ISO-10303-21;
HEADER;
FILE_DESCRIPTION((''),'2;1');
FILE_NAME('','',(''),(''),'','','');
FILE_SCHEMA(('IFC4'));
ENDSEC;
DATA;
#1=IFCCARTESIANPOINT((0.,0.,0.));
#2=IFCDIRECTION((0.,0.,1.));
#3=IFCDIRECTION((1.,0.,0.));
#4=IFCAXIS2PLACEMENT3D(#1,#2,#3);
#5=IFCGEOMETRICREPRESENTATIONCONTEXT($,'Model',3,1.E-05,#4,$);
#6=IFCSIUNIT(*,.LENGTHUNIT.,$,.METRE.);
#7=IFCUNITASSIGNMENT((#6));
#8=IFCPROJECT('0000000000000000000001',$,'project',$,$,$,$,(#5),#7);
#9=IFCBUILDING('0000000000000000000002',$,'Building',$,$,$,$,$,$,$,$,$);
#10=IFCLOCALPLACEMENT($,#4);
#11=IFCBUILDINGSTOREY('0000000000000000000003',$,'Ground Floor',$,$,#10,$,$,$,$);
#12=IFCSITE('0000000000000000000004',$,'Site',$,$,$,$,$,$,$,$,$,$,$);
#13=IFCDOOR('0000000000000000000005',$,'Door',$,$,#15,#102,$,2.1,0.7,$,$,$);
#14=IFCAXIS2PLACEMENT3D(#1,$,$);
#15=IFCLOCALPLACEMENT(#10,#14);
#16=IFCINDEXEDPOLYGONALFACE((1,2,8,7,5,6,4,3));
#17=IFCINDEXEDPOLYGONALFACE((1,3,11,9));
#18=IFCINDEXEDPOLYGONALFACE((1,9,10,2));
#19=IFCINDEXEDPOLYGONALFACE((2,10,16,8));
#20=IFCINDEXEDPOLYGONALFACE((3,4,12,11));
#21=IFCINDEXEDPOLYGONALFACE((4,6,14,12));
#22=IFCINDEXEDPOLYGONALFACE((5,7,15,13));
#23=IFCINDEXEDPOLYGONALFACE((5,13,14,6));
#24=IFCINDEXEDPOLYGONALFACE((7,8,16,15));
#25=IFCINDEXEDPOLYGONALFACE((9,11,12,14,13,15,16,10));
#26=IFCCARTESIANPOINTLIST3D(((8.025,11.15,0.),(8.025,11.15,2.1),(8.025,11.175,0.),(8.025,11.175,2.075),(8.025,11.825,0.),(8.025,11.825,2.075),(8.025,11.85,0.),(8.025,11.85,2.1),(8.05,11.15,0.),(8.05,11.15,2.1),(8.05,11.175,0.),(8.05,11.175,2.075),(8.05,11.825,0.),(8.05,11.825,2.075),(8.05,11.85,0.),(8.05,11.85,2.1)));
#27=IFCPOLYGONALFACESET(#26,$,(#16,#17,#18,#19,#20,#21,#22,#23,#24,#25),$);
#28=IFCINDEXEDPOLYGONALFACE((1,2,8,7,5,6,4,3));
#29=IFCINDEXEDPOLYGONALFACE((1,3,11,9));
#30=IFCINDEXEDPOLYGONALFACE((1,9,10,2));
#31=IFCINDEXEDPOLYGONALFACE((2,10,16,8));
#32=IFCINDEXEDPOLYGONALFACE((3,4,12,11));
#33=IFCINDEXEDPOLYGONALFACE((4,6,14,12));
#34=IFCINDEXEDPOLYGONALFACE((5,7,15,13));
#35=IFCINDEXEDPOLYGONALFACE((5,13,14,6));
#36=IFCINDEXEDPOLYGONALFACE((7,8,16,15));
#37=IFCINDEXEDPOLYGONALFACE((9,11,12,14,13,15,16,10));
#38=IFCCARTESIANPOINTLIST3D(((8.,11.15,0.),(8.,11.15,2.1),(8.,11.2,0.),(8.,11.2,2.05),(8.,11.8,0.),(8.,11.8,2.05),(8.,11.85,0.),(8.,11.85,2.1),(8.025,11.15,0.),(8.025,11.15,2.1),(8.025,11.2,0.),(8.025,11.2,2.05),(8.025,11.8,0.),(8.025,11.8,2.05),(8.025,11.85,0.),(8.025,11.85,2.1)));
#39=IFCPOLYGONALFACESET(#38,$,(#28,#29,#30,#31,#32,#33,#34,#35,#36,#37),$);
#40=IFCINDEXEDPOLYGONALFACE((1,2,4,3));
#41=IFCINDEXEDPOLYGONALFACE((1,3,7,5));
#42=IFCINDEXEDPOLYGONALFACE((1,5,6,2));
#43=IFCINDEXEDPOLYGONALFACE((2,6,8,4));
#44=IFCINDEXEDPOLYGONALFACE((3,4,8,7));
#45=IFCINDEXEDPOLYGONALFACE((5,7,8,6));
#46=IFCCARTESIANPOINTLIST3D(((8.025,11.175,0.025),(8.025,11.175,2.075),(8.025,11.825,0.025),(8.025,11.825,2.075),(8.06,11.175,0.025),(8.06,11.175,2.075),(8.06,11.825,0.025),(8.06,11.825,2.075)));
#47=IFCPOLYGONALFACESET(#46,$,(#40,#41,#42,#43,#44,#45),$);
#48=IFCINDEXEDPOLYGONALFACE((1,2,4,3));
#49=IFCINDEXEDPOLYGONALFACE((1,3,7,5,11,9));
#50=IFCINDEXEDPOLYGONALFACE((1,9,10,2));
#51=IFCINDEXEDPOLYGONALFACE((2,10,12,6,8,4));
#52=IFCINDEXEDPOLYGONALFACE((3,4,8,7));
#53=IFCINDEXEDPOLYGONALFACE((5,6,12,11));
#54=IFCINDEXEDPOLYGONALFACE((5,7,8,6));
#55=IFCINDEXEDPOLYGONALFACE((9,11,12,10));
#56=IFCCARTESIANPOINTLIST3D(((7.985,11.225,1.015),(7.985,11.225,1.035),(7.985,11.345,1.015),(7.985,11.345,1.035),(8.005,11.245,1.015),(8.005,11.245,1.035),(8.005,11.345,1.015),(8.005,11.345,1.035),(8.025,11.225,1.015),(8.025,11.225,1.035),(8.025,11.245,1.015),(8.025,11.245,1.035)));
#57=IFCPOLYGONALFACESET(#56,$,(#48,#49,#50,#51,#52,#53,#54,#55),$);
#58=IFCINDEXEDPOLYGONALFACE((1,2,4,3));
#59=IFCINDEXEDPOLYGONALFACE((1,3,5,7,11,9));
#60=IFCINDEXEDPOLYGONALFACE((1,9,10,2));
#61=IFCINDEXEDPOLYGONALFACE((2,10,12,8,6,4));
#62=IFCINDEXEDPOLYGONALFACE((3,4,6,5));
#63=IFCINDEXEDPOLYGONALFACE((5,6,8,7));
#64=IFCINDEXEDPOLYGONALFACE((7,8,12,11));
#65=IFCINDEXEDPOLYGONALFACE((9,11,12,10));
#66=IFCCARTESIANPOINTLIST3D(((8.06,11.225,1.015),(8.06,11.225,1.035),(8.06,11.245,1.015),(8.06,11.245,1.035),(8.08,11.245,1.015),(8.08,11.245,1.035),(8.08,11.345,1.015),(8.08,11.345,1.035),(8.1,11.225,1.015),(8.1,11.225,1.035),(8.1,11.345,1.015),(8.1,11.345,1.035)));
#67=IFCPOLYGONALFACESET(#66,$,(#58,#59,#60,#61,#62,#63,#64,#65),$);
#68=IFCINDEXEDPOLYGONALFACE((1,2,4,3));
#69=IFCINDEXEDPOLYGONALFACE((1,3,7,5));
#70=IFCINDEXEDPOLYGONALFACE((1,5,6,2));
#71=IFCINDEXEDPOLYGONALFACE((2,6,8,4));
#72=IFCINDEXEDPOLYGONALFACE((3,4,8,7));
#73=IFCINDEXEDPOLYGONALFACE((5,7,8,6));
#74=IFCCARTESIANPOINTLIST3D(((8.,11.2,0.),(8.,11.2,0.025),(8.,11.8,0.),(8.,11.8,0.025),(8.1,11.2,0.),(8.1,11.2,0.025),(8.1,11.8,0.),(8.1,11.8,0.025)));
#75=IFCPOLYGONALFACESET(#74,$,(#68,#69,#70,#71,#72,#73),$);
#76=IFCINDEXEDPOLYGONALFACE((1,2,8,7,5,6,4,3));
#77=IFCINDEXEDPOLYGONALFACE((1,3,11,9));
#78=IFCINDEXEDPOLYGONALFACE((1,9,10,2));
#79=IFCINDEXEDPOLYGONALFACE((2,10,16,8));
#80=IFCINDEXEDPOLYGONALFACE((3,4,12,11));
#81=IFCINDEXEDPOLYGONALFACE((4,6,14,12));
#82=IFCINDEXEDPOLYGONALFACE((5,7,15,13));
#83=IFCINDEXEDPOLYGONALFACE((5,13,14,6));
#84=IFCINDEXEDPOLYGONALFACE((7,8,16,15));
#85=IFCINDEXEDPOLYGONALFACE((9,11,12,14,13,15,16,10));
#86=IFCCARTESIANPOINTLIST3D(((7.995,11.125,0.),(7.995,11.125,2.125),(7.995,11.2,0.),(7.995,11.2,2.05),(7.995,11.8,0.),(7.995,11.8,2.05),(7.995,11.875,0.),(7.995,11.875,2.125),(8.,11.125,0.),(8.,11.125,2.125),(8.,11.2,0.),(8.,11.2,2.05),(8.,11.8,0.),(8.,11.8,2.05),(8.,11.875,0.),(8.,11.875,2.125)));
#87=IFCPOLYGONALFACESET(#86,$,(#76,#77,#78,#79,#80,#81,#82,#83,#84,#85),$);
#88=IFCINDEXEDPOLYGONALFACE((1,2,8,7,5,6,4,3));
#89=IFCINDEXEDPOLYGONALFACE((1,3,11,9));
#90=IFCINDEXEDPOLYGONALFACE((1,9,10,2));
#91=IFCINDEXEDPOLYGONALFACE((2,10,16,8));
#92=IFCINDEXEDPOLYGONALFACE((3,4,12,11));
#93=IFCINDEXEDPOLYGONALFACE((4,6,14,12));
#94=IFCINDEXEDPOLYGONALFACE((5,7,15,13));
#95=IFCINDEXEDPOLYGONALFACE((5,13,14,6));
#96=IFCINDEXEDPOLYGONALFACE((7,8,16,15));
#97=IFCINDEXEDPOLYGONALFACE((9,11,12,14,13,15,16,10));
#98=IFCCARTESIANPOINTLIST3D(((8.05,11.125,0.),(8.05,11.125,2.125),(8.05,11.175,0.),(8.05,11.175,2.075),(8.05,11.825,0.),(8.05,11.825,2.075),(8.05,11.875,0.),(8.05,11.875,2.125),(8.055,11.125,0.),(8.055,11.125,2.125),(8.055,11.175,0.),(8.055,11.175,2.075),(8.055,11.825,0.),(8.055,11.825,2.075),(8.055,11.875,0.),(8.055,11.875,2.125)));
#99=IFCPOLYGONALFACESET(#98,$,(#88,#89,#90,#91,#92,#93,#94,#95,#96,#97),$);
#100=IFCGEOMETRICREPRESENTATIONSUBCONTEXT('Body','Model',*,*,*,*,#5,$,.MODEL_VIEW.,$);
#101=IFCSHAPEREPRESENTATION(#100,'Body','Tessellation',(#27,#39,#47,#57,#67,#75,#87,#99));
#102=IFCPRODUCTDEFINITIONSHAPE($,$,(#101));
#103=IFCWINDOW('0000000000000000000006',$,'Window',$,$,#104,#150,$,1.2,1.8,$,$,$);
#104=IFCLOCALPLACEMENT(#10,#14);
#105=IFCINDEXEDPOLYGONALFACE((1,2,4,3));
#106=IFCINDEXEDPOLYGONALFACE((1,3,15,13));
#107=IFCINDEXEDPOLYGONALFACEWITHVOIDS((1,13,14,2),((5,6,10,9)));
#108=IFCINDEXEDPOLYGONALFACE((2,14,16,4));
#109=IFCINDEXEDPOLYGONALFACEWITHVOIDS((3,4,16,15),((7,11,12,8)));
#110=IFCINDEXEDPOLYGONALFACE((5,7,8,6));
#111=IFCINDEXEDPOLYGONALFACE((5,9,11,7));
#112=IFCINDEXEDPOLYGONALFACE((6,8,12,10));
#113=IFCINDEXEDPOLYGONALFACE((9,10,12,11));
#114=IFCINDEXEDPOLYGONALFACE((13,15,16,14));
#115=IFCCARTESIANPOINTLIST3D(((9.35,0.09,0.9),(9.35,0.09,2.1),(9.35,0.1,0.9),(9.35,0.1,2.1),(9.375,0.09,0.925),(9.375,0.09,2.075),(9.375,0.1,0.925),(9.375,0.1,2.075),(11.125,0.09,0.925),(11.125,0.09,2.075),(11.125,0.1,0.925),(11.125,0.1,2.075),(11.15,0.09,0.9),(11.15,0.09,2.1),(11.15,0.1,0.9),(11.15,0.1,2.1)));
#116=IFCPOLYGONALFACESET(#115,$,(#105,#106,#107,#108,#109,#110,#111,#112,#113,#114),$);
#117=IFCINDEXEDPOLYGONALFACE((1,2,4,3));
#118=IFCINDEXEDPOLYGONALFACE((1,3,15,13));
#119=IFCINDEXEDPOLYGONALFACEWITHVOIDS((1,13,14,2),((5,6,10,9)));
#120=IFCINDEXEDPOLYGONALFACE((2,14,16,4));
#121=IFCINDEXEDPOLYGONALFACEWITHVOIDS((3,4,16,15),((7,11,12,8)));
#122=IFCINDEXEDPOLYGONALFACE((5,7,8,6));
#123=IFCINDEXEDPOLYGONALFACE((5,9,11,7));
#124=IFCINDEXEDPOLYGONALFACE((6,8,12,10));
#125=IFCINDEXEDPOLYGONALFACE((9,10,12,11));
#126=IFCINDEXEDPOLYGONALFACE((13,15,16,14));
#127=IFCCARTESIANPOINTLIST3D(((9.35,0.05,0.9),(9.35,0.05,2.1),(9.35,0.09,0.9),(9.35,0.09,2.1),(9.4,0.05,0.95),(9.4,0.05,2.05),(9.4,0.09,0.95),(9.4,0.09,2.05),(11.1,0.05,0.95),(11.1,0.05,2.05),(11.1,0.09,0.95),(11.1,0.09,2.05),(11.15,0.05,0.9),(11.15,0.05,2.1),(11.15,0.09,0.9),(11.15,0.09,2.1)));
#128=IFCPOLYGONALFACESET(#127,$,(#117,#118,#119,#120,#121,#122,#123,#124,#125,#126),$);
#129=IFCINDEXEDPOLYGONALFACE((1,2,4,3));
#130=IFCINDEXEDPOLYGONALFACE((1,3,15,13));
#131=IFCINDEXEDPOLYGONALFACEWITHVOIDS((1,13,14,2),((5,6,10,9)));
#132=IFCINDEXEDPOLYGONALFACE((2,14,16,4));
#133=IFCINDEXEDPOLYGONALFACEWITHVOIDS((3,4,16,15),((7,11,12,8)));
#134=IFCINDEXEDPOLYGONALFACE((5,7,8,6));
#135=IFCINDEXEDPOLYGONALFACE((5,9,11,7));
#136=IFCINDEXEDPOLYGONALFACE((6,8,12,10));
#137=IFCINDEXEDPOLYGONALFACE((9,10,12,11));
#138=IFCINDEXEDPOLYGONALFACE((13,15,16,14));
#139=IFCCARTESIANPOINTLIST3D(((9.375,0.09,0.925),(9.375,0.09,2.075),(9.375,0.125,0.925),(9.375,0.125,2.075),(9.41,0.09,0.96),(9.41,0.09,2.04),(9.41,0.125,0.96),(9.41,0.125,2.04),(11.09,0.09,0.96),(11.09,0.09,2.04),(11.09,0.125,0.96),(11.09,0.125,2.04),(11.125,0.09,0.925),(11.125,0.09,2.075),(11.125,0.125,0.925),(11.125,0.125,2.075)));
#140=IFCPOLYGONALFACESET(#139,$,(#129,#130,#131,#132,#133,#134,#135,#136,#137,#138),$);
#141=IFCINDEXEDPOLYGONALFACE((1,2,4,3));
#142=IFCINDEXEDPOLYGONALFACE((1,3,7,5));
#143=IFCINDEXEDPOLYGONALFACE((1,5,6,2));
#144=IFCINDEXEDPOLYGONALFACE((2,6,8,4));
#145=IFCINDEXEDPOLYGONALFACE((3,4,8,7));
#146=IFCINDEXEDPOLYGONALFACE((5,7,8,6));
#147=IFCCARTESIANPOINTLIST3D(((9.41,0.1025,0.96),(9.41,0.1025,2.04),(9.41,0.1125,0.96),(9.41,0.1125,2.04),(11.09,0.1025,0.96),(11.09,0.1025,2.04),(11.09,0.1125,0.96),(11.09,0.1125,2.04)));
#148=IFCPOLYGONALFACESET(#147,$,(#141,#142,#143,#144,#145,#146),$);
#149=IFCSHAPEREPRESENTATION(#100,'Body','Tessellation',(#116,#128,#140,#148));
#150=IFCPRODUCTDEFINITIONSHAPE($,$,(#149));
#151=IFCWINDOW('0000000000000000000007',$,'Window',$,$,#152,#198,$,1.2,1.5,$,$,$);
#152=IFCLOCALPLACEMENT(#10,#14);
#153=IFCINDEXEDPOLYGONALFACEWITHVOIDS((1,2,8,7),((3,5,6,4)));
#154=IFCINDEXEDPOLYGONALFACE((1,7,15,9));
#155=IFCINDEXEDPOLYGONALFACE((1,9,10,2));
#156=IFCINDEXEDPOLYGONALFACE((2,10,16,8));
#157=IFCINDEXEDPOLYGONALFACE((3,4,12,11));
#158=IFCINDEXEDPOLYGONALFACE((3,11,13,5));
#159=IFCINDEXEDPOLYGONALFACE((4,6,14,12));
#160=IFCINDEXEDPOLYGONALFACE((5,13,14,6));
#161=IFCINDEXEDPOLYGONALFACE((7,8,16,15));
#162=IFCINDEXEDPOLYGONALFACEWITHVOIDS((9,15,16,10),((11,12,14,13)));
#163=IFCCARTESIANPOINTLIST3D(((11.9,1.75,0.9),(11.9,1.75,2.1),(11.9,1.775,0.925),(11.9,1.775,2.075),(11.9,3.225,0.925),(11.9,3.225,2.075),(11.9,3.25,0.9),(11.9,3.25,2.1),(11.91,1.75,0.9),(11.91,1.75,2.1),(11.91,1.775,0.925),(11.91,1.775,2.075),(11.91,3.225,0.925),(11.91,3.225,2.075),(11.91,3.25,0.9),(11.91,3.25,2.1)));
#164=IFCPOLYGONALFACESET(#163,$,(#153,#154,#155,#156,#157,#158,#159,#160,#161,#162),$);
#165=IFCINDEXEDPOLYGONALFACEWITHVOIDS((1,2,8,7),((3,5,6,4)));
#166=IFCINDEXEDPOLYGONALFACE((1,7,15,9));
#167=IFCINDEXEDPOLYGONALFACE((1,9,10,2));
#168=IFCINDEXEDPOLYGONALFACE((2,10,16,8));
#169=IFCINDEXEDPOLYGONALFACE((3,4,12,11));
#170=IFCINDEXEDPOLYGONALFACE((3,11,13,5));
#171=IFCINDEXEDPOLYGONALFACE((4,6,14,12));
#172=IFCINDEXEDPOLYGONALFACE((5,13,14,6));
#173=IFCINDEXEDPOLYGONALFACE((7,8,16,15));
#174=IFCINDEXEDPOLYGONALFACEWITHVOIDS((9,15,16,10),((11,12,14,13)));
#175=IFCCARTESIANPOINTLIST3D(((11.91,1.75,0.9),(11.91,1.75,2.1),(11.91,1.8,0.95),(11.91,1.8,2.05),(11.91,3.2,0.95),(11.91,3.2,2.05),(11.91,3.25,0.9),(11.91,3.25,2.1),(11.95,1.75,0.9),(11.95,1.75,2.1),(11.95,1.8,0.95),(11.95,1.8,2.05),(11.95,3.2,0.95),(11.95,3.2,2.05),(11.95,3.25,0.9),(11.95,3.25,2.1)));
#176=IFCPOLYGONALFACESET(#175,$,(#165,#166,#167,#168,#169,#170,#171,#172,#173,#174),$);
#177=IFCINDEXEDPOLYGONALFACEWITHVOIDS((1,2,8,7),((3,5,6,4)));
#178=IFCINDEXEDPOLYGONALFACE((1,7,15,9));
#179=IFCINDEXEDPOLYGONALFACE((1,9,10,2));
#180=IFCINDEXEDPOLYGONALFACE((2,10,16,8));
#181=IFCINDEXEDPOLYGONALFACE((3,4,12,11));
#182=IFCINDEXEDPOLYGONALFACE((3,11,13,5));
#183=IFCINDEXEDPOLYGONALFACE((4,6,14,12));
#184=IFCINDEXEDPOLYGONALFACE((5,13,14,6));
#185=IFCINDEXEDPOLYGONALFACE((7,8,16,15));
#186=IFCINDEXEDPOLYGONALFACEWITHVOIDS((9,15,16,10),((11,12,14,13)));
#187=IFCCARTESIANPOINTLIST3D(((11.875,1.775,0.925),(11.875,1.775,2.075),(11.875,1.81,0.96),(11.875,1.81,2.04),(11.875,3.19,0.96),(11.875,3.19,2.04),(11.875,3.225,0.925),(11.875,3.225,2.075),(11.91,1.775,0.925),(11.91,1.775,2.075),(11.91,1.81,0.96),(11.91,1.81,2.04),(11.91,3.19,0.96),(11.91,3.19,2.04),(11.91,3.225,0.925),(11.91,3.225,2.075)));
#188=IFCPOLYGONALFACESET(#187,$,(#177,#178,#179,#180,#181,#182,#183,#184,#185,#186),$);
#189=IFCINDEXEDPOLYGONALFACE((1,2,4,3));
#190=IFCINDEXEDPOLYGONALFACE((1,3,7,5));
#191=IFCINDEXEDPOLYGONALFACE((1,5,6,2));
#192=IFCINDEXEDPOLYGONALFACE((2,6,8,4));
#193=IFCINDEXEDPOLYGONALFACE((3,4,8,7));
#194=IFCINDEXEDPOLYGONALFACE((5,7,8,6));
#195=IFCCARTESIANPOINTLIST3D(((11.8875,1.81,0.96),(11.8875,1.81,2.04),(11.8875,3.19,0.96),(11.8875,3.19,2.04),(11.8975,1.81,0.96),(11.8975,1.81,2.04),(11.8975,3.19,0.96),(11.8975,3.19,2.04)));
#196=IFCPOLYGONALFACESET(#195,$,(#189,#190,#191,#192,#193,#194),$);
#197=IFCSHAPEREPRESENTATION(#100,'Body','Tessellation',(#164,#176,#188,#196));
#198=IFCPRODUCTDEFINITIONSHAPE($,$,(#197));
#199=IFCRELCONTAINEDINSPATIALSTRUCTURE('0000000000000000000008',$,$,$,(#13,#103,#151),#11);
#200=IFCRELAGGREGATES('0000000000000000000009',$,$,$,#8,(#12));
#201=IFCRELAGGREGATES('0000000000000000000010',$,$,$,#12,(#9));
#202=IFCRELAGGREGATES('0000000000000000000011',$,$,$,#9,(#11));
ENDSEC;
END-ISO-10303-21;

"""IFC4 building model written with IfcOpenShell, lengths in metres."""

from ifc_helpers import new_model, si_unit, frame, origin_with_axes, place, context, subcontext, project, spatial, line, indexed_curve, outline, extrude, element, save


model = new_model("IFC4")

# Units and contexts
model_context = context("Model", 3, precision=1e-05, world=origin_with_axes())
body_context = subcontext(model_context, "Body", "Model", "MODEL_VIEW")
ifc_project = project(units=[si_unit("LENGTHUNIT", "METRE")], contexts=[model_context])

# Site, building, storey
site = spatial("IfcSite", under=ifc_project, Name="Site")
building = spatial("IfcBuilding", under=site, Name="Building")
storey_placement = place(None, origin_with_axes())
storey = spatial("IfcBuildingStorey", under=building, at=storey_placement, Name="Ground Floor")

# Door
door_1_placement = place(storey_placement, frame((8.0, 11.85, 0.0), z_axis=(0.0, 0.0, 1.0), x_axis=(0.0, -1.0, 0.0)))
element("IfcDoor", 1, at=door_1_placement, inside=storey, Name="Door", OverallHeight=2.1, OverallWidth=0.7, context=body_context, shape_type="SweptSolid", body=[
    extrude(outline(indexed_curve([(0.0, 0.0), (0.0, 2.1), (0.7, 2.1), (0.7, 0.0), (0.675, 0.0), (0.675, 2.075), (0.025, 2.075), (0.025, 0.0)], segments=[line(1, 2, 3, 4, 5, 6, 7, 8, 1)])), frame((0.0, 0.025, 0.0), z_axis=(0.0, -1.0, 0.0), x_axis=(1.0, 0.0, 0.0)), (0.0, 0.0, -1.0), 0.025),
    extrude(outline(indexed_curve([(0.0, 0.0), (0.0, 2.1), (0.7, 2.1), (0.7, 0.0), (0.65, 0.0), (0.65, 2.05), (0.05, 2.05), (0.05, 0.0)], segments=[line(1, 2, 3, 4, 5, 6, 7, 8, 1)])), frame((0.0, 0.0, 0.0), z_axis=(0.0, -1.0, 0.0), x_axis=(1.0, 0.0, 0.0)), (0.0, 0.0, -1.0), 0.025),
    extrude(outline(indexed_curve([(0.0, 0.0), (0.65, 0.0), (0.65, 0.035), (0.0, 0.035)], segments=[line(1, 2, 3, 4, 1)])), frame((0.025, 0.025, 0.025), z_axis=(0.0, 0.0, 1.0), x_axis=(1.0, 0.0, 0.0)), (0.0, 0.0, 1.0), 2.05),
    extrude(outline(indexed_curve([(0.0, 0.0), (0.0, -0.04), (-0.12, -0.04), (-0.12, -0.02), (-0.02, -0.02), (-0.02, 0.0)], segments=[line(1, 2, 3, 4, 5, 6, 1)])), frame((0.625, 0.025, 1.015), z_axis=(0.0, 0.0, 1.0), x_axis=(1.0, 0.0, 0.0)), (0.0, 0.0, 1.0), 0.02),
    extrude(outline(indexed_curve([(0.0, 0.0), (0.0, 0.04), (-0.12, 0.04), (-0.12, 0.02), (-0.02, 0.02), (-0.02, 0.0)], segments=[line(1, 2, 3, 4, 5, 6, 1)])), frame((0.625, 0.06, 1.015), z_axis=(0.0, 0.0, 1.0), x_axis=(1.0, 0.0, 0.0)), (0.0, 0.0, 1.0), 0.02),
    extrude(outline(indexed_curve([(0.0, 0.0), (0.6, 0.0), (0.6, 0.1), (0.0, 0.1)], segments=[line(1, 2, 3, 4, 1)])), frame((0.05, 0.0, 0.0), z_axis=(0.0, 0.0, 1.0), x_axis=(1.0, 0.0, 0.0)), (0.0, 0.0, 1.0), 0.025),
    extrude(outline(indexed_curve([(0.0, 0.0), (0.0, 2.125), (0.75, 2.125), (0.75, 0.0), (0.675, 0.0), (0.675, 2.05), (0.075, 2.05), (0.075, 0.0)], segments=[line(1, 2, 3, 4, 5, 6, 7, 8, 1)])), frame((-0.025, -0.005, 0.0), z_axis=(0.0, -1.0, 0.0), x_axis=(1.0, 0.0, 0.0)), (0.0, 0.0, -1.0), 0.005),
    extrude(outline(indexed_curve([(0.0, 0.0), (0.0, 2.125), (0.75, 2.125), (0.75, 0.0), (0.7, 0.0), (0.7, 2.075), (0.05, 2.075), (0.05, 0.0)], segments=[line(1, 2, 3, 4, 5, 6, 7, 8, 1)])), frame((-0.025, 0.05, 0.0), z_axis=(0.0, -1.0, 0.0), x_axis=(1.0, 0.0, 0.0)), (0.0, 0.0, -1.0), 0.005),
])

# Windows
window_1_placement = place(storey_placement, frame((9.35, 0.0, 0.9), z_axis=(0.0, 0.0, 1.0), x_axis=(1.0, 0.0, 0.0)))
element("IfcWindow", 2, at=window_1_placement, inside=storey, Name="Window", OverallHeight=1.2, OverallWidth=1.8, context=body_context, shape_type="SweptSolid", body=[
    extrude(outline(indexed_curve([(0.0, 0.0), (1.8, 0.0), (1.8, 1.2), (0.0, 1.2)], segments=[line(1, 2, 3, 4, 1)]), holes=[indexed_curve([(0.025, 0.025), (1.775, 0.025), (1.775, 1.175), (0.025, 1.175)], segments=[line(1, 2, 3, 4, 1)])]), frame((0.0, 0.09, 0.0), z_axis=(0.0, -1.0, 0.0), x_axis=(1.0, 0.0, 0.0)), (0.0, 0.0, -1.0), 0.01),
    extrude(outline(indexed_curve([(0.0, 0.0), (1.8, 0.0), (1.8, 1.2), (0.0, 1.2)], segments=[line(1, 2, 3, 4, 1)]), holes=[indexed_curve([(0.05, 0.05), (1.75, 0.05), (1.75, 1.15), (0.05, 1.15)], segments=[line(1, 2, 3, 4, 1)])]), frame((0.0, 0.05, 0.0), z_axis=(0.0, -1.0, 0.0), x_axis=(1.0, 0.0, 0.0)), (0.0, 0.0, -1.0), 0.04),
    extrude(outline(indexed_curve([(0.0, 0.0), (1.75, 0.0), (1.75, 1.15), (0.0, 1.15)], segments=[line(1, 2, 3, 4, 1)]), holes=[indexed_curve([(0.035, 0.035), (1.715, 0.035), (1.715, 1.115), (0.035, 1.115)], segments=[line(1, 2, 3, 4, 1)])]), frame((0.025, 0.09, 0.025), z_axis=(0.0, -1.0, 0.0), x_axis=(1.0, 0.0, 0.0)), (0.0, 0.0, -1.0), 0.035),
    extrude(outline(indexed_curve([(0.035, 0.035), (1.715, 0.035), (1.715, 1.115), (0.035, 1.115)], segments=[line(1, 2, 3, 4, 1)])), frame((0.025, 0.1025, 0.025), z_axis=(0.0, -1.0, 0.0), x_axis=(1.0, 0.0, 0.0)), (0.0, 0.0, -1.0), 0.01),
])
for number, where, z_axis, x_axis, name in (
    (3, (12.0, 1.75, 0.9), (0.0, 0.0, 1.0), (0.0, 1.0, 0.0), "Window"),
):
    element("IfcWindow", number, at=place(storey_placement, frame(where, z_axis=z_axis, x_axis=x_axis)), inside=storey, Name=name, OverallHeight=1.2, OverallWidth=1.5, context=body_context, shape_type="SweptSolid", body=[
        extrude(outline(indexed_curve([(0.0, 0.0), (1.5, 0.0), (1.5, 1.2), (0.0, 1.2)], segments=[line(1, 2, 3, 4, 1)]), holes=[indexed_curve([(0.025, 0.025), (1.475, 0.025), (1.475, 1.175), (0.025, 1.175)], segments=[line(1, 2, 3, 4, 1)])]), frame((0.0, 0.09, 0.0), z_axis=(0.0, -1.0, 0.0), x_axis=(1.0, 0.0, 0.0)), (0.0, 0.0, -1.0), 0.01),
        extrude(outline(indexed_curve([(0.0, 0.0), (1.5, 0.0), (1.5, 1.2), (0.0, 1.2)], segments=[line(1, 2, 3, 4, 1)]), holes=[indexed_curve([(0.05, 0.05), (1.45, 0.05), (1.45, 1.15), (0.05, 1.15)], segments=[line(1, 2, 3, 4, 1)])]), frame((0.0, 0.05, 0.0), z_axis=(0.0, -1.0, 0.0), x_axis=(1.0, 0.0, 0.0)), (0.0, 0.0, -1.0), 0.04),
        extrude(outline(indexed_curve([(0.0, 0.0), (1.45, 0.0), (1.45, 1.15), (0.0, 1.15)], segments=[line(1, 2, 3, 4, 1)]), holes=[indexed_curve([(0.035, 0.035), (1.415, 0.035), (1.415, 1.115), (0.035, 1.115)], segments=[line(1, 2, 3, 4, 1)])]), frame((0.025, 0.09, 0.025), z_axis=(0.0, -1.0, 0.0), x_axis=(1.0, 0.0, 0.0)), (0.0, 0.0, -1.0), 0.035),
        extrude(outline(indexed_curve([(0.035, 0.035), (1.415, 0.035), (1.415, 1.115), (0.035, 1.115)], segments=[line(1, 2, 3, 4, 1)])), frame((0.025, 0.1025, 0.025), z_axis=(0.0, -1.0, 0.0), x_axis=(1.0, 0.0, 0.0)), (0.0, 0.0, -1.0), 0.01),
    ])

save(model, "model.ifc")
